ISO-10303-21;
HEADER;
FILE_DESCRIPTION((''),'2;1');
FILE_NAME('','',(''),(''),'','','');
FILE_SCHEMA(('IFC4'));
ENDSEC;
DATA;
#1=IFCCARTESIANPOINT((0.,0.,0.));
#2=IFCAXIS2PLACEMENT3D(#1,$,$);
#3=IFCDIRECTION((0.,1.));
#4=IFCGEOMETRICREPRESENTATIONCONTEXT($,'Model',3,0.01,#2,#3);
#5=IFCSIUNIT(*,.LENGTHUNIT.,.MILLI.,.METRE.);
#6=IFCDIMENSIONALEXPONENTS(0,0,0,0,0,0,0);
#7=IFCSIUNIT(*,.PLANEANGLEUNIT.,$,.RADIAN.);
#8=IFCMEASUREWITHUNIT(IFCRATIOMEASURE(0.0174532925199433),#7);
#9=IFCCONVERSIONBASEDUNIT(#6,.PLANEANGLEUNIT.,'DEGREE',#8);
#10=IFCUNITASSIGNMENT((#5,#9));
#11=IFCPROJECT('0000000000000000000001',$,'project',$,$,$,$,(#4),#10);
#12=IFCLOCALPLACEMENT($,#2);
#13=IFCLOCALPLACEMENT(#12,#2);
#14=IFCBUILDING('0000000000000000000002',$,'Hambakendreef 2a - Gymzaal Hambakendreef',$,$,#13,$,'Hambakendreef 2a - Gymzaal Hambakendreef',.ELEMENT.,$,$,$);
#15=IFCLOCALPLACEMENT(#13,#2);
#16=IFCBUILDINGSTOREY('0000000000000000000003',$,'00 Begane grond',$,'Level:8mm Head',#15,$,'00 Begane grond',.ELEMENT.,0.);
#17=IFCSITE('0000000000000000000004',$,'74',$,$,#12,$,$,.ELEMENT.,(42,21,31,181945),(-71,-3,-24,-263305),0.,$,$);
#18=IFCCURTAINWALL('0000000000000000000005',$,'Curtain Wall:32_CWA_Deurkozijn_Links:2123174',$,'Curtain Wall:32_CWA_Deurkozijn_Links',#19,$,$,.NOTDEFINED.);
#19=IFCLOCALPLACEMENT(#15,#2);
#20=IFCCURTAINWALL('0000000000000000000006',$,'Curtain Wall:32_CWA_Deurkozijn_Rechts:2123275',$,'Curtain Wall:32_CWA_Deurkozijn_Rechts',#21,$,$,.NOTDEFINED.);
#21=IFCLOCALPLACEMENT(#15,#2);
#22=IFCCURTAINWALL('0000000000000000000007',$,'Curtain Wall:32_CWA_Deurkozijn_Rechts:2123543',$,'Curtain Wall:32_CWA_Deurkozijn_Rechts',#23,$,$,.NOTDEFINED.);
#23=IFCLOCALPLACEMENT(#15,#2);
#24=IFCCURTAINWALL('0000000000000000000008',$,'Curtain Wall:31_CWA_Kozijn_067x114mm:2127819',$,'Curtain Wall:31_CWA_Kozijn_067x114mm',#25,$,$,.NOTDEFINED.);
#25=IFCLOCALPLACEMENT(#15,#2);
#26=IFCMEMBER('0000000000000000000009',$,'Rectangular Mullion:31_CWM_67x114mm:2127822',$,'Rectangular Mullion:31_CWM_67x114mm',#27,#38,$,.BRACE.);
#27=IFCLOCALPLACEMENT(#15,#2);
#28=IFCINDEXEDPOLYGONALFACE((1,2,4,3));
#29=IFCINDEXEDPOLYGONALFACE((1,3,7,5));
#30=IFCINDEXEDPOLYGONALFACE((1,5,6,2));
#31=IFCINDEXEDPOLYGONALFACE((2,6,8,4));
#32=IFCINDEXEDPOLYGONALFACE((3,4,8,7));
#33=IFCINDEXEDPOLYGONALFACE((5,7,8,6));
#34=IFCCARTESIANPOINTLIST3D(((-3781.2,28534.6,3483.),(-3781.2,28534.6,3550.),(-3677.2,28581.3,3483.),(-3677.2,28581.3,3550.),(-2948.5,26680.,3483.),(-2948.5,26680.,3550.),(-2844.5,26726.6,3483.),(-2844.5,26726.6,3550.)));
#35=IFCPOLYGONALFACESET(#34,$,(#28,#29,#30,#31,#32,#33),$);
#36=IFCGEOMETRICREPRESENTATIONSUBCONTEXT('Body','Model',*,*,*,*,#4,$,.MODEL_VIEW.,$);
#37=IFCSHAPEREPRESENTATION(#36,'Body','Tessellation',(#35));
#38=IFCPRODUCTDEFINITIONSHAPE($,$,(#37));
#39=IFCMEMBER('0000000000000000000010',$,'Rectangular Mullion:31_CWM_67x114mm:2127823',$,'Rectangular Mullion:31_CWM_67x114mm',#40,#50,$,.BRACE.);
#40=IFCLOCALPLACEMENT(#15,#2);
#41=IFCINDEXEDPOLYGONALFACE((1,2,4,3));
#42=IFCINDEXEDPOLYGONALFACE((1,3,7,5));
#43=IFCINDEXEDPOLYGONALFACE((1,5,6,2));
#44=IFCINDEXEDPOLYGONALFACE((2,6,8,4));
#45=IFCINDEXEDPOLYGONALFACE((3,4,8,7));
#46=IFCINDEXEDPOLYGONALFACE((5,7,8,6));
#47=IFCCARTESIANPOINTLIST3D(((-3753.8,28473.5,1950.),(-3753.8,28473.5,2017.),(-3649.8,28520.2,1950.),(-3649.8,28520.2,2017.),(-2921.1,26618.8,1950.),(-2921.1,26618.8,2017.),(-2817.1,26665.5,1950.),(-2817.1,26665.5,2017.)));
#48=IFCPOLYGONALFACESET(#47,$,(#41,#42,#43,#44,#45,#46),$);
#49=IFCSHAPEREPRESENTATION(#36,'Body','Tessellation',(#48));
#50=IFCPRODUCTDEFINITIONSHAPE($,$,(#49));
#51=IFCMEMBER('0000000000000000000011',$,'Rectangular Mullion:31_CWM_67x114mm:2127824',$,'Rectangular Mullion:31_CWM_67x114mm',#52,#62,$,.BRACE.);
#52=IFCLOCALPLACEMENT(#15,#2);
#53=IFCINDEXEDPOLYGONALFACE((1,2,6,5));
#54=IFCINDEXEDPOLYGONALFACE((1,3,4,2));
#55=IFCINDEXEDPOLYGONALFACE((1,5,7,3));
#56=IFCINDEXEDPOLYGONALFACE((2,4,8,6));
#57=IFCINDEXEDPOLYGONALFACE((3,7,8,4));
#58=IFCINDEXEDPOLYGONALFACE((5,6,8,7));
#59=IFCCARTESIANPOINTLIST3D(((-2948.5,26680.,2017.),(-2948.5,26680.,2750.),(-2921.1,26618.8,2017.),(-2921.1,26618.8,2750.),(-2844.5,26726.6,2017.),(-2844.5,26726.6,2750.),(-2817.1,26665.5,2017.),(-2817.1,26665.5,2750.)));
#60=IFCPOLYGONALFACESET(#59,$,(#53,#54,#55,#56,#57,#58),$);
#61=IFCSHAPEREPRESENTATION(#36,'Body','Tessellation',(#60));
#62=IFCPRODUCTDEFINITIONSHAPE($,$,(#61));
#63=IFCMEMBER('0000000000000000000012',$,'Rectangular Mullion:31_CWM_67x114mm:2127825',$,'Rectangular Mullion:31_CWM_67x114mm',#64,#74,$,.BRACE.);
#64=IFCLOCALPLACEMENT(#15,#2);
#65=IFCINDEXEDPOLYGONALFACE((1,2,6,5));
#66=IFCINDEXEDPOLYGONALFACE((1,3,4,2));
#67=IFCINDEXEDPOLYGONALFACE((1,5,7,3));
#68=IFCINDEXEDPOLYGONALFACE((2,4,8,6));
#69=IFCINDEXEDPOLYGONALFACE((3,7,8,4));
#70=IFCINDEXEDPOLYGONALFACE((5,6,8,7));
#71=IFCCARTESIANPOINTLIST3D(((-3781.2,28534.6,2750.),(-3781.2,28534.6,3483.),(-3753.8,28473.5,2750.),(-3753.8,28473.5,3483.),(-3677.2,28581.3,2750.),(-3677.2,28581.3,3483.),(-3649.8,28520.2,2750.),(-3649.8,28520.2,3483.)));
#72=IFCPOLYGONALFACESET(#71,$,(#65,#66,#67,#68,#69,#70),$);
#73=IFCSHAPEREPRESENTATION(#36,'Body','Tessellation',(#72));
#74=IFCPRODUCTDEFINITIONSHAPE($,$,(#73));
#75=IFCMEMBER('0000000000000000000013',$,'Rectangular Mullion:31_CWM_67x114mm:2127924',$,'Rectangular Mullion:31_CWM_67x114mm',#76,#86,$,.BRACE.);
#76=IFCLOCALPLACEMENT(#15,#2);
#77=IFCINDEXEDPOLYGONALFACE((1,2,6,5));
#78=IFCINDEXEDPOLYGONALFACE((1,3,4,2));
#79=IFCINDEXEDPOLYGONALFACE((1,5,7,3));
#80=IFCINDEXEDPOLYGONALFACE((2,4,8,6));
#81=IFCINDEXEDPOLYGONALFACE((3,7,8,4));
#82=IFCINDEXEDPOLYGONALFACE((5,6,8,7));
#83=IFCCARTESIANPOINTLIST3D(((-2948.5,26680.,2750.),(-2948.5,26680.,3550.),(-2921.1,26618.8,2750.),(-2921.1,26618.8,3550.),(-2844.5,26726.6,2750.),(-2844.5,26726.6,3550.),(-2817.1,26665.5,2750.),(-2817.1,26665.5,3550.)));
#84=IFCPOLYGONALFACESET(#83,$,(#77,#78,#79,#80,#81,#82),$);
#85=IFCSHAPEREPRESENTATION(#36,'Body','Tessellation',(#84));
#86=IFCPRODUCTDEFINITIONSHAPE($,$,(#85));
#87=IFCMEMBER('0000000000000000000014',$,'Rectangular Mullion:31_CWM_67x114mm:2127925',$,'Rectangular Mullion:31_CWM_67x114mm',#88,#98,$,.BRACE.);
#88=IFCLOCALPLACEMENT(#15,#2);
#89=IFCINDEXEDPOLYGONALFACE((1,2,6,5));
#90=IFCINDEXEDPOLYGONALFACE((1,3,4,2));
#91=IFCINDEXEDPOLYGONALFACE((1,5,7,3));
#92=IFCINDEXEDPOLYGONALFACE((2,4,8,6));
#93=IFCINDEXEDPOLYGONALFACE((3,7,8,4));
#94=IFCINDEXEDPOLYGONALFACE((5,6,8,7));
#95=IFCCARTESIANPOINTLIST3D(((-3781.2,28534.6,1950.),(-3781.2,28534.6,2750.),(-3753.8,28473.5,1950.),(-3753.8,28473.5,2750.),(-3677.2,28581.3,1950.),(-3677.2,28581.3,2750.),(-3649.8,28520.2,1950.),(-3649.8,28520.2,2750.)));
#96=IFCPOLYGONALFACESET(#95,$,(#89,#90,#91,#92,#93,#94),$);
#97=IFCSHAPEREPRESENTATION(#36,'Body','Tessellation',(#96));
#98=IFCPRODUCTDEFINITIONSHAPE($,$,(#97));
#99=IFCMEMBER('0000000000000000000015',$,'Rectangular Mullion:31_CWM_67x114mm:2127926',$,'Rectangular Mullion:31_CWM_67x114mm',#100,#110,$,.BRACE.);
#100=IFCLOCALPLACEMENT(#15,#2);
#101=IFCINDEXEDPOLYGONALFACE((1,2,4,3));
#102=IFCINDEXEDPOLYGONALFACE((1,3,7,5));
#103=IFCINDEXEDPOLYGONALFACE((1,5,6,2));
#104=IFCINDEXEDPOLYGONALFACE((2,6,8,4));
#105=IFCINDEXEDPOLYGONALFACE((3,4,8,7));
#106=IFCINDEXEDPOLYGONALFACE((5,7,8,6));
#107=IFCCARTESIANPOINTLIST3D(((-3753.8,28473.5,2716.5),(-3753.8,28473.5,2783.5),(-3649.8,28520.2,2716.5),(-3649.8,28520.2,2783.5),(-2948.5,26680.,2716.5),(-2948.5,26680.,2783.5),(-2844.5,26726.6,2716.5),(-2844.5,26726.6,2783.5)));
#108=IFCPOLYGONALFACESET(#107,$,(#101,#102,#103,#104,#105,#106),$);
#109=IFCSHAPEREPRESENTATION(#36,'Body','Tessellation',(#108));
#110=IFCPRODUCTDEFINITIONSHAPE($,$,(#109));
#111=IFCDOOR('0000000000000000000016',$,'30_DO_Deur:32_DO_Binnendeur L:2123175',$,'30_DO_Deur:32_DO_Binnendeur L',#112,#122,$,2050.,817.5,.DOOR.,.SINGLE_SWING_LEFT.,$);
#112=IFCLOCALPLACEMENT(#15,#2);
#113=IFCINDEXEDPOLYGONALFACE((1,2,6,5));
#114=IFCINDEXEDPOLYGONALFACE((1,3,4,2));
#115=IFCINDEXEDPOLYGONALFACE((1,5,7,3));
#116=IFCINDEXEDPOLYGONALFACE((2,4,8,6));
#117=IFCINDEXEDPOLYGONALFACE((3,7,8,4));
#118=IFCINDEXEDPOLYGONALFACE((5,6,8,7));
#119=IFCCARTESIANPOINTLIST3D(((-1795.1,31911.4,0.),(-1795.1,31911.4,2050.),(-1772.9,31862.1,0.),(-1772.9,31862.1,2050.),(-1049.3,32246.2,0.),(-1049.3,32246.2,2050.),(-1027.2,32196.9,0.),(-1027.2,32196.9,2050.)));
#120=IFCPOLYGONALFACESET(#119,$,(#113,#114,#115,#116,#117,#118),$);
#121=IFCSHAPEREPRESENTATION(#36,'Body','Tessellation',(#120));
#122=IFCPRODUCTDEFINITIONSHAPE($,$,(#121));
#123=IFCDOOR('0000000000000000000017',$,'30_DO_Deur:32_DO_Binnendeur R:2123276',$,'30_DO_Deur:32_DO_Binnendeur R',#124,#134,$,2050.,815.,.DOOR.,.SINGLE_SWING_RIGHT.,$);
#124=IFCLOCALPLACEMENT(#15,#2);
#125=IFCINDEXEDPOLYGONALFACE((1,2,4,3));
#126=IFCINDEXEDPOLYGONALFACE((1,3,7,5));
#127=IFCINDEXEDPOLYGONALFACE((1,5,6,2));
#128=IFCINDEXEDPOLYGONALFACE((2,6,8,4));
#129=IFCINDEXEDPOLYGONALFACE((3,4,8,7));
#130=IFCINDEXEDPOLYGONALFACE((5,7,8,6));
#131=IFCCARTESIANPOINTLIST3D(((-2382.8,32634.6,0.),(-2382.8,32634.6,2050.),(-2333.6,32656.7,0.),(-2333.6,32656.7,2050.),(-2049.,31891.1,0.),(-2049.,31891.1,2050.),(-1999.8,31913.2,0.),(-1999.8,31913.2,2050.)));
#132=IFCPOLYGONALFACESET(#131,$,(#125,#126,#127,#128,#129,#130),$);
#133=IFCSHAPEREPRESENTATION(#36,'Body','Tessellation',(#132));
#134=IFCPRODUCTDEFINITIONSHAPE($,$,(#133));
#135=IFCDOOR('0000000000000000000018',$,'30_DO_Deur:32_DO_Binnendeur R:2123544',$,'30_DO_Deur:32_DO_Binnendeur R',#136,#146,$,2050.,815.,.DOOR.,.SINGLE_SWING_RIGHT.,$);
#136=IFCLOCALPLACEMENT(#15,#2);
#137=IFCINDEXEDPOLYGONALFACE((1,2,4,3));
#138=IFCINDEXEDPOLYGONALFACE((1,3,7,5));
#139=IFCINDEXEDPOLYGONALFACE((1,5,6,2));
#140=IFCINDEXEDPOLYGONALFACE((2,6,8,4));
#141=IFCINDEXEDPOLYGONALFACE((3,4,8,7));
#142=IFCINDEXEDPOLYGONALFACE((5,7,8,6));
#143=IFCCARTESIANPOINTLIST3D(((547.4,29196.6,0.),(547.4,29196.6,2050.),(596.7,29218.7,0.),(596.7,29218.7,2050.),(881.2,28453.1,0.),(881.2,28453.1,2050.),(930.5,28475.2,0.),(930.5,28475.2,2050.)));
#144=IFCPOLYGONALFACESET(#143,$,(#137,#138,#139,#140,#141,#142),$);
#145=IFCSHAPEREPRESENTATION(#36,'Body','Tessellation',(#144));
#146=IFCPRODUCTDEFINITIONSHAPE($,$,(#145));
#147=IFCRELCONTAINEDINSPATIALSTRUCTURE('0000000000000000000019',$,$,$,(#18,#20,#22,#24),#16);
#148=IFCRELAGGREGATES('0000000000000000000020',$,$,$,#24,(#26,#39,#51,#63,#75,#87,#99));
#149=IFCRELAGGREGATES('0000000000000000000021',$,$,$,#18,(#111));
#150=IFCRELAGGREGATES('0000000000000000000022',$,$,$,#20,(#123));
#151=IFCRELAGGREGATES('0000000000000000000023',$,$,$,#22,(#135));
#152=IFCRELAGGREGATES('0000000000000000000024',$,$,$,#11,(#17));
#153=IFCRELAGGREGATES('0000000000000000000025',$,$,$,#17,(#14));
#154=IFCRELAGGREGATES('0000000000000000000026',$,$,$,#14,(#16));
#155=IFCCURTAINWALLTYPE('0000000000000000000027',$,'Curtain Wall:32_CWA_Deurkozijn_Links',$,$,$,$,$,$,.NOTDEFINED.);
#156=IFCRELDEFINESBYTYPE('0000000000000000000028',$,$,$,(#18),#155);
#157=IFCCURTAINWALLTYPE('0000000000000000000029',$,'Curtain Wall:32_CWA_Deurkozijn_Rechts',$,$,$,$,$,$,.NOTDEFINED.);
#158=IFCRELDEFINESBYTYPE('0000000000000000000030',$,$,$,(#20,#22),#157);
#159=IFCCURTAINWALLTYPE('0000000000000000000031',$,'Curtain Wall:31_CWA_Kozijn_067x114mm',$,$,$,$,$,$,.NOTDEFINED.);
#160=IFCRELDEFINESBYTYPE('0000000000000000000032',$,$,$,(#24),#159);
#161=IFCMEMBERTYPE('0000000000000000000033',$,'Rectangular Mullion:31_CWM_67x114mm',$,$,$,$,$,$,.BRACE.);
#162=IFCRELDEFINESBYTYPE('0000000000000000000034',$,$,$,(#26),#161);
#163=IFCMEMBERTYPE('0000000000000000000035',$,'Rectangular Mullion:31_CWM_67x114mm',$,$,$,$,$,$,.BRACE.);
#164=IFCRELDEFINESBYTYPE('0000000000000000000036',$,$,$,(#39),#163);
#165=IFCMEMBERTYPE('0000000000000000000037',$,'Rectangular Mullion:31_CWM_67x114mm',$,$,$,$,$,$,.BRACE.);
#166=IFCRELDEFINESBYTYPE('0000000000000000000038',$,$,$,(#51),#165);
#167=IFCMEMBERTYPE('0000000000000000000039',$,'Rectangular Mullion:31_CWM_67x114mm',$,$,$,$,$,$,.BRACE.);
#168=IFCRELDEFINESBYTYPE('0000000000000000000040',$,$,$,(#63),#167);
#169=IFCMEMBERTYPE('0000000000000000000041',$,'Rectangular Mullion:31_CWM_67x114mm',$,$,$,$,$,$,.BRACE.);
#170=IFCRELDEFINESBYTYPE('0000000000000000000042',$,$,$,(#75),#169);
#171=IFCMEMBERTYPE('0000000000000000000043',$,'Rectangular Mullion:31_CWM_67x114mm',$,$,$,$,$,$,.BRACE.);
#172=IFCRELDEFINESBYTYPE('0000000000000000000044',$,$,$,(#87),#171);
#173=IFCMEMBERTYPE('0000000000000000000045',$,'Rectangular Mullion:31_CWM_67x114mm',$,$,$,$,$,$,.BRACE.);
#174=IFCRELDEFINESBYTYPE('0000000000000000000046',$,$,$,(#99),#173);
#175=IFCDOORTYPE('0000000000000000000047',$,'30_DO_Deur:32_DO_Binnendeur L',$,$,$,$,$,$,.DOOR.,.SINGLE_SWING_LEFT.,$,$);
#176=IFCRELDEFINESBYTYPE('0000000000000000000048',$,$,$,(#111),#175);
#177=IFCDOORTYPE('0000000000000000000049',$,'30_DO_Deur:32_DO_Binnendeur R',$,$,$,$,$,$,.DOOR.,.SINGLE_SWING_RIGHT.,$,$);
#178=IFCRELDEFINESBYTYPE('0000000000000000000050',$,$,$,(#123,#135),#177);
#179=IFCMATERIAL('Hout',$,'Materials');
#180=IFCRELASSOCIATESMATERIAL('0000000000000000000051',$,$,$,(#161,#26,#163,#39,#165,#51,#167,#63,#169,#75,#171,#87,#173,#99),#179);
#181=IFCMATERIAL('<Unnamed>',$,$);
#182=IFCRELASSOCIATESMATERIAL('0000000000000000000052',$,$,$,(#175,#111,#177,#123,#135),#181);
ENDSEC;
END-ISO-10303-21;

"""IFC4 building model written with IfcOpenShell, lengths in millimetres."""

from ifc_helpers import new_model, entity, si_unit, converted_unit, direction, frame, origin, place, context, subcontext, project, spatial, indexed_curve, outline, extrude, source, transform, mapped, material, type_object, type_shapes, element, aggregate, save


model = new_model("IFC4")

# Units and contexts
model_context = context("Model", 3, precision=0.01, world=origin(), true_north=direction((0.0, 1.0)))
body_context = subcontext(model_context, "Body", "Model", "MODEL_VIEW")
ifc_project = project(units=[si_unit("LENGTHUNIT", "METRE", prefix="MILLI"), converted_unit("PLANEANGLEUNIT", "DEGREE", entity("IfcRatioMeasure", 0.0174532925199433), si_unit("PLANEANGLEUNIT", "RADIAN"), dimensions=[0, 0, 0, 0, 0, 0, 0])], contexts=[model_context])

# Site, building, storey
site_placement = place(None, origin())
site = spatial("IfcSite", under=ifc_project, at=site_placement, Name="74", CompositionType="ELEMENT", RefLatitude=(42, 21, 31, 181945), RefLongitude=(-71, -3, -24, -263305), RefElevation=0.0)
building_placement = place(site_placement, origin())
building = spatial("IfcBuilding", under=site, at=building_placement, Name="Hambakendreef 2a - Gymzaal Hambakendreef", LongName="Hambakendreef 2a - Gymzaal Hambakendreef", CompositionType="ELEMENT")
storey_placement = place(building_placement, origin())
storey = spatial("IfcBuildingStorey", under=building, at=storey_placement, Name="00 Begane grond", ObjectType="Level:8mm Head", LongName="00 Begane grond", CompositionType="ELEMENT", Elevation=0.0)

# Curtain walls
curtain_wall_type_1 = type_object("IfcCurtainWallType", Name="Curtain Wall:32_CWA_Deurkozijn_Rechts", PredefinedType="NOTDEFINED")
ifc_material_1 = material(Name="Hout", Category="Materials")
curtain_wall_type_2 = type_object("IfcCurtainWallType", Name="Curtain Wall:32_CWA_Deurkozijn_Links", PredefinedType="NOTDEFINED")
curtain_wall_1_placement = place(storey_placement, origin())
curtain_wall_1 = element("IfcCurtainWall", 1, at=curtain_wall_1_placement, inside=storey, type_object=curtain_wall_type_2, Name="Curtain Wall:32_CWA_Deurkozijn_Links:2123174", ObjectType="Curtain Wall:32_CWA_Deurkozijn_Links", PredefinedType="NOTDEFINED")
curtain_wall_2_placement = place(storey_placement, origin())
curtain_wall_2 = element("IfcCurtainWall", 2, at=curtain_wall_2_placement, inside=storey, type_object=curtain_wall_type_1, Name="Curtain Wall:32_CWA_Deurkozijn_Rechts:2123275", ObjectType="Curtain Wall:32_CWA_Deurkozijn_Rechts", PredefinedType="NOTDEFINED")

# Curtain wall
curtain_wall_3_placement = place(storey_placement, origin())
curtain_wall_3 = element("IfcCurtainWall", 3, at=curtain_wall_3_placement, inside=storey, type_object=curtain_wall_type_1, Name="Curtain Wall:32_CWA_Deurkozijn_Rechts:2123543", ObjectType="Curtain Wall:32_CWA_Deurkozijn_Rechts", PredefinedType="NOTDEFINED")

# Curtain wall, members
curtain_wall_type_3 = type_object("IfcCurtainWallType", Name="Curtain Wall:31_CWA_Kozijn_067x114mm", PredefinedType="NOTDEFINED")
curtain_wall_4_placement = place(storey_placement, origin())
curtain_wall_4 = element("IfcCurtainWall", 4, at=curtain_wall_4_placement, inside=storey, type_object=curtain_wall_type_3, Name="Curtain Wall:31_CWA_Kozijn_067x114mm:2127819", ObjectType="Curtain Wall:31_CWA_Kozijn_067x114mm", PredefinedType="NOTDEFINED")
member_type_1 = type_object("IfcMemberType", Name="Rectangular Mullion:31_CWM_67x114mm", PredefinedType="BRACE", material=ifc_material_1)
shared_shape_1 = source(origin(), body_context, "Body", "SweptSolid", [
    extrude(outline(indexed_curve([(-57.0, -33.5), (57.0, -33.5), (57.0, 33.5), (-57.0, 33.5), (-57.0, -33.5)], self_intersect=False)), frame((-33.5, 0.0, -2033.0), z_axis=(0.0, 0.0, 1.0), x_axis=(0.0, -1.0, 0.0)), (0.0, 0.0, 1.0), 2033.0),
])
type_shapes(member_type_1, [shared_shape_1])
member_1_placement = place(storey_placement, frame((-2896.5, 26703.3, 3550.0), z_axis=(0.40959, -0.91227, 0.0), x_axis=(0.0, 0.0, 1.0)))
member_1 = element("IfcMember", 5, at=member_1_placement, type_object=member_type_1, material=ifc_material_1, Name="Rectangular Mullion:31_CWM_67x114mm:2127822", ObjectType="Rectangular Mullion:31_CWM_67x114mm", PredefinedType="BRACE", context=body_context, shape_type="MappedRepresentation", body=[
    mapped(shared_shape_1, transform((0.0, 0.0, 0.0), scale=1.0)),
])
member_type_2 = type_object("IfcMemberType", Name="Rectangular Mullion:31_CWM_67x114mm", PredefinedType="BRACE", material=ifc_material_1)
shared_shape_2 = source(origin(), body_context, "Body", "SweptSolid", [
    extrude(outline(indexed_curve([(-57.0, -33.5), (57.0, -33.5), (57.0, 33.5), (-57.0, 33.5), (-57.0, -33.5)], self_intersect=False)), frame((-33.5, 0.0, -2033.0), z_axis=(0.0, 0.0, 1.0), x_axis=(0.0, -1.0, 0.0)), (0.0, 0.0, 1.0), 2033.0),
])
type_shapes(member_type_2, [shared_shape_2])
member_2_placement = place(storey_placement, frame((-3701.8, 28496.8, 1950.0), z_axis=(-0.40959, 0.91227, 0.0), x_axis=(0.0, 0.0, -1.0)))
member_2 = element("IfcMember", 6, at=member_2_placement, type_object=member_type_2, material=ifc_material_1, Name="Rectangular Mullion:31_CWM_67x114mm:2127823", ObjectType="Rectangular Mullion:31_CWM_67x114mm", PredefinedType="BRACE", context=body_context, shape_type="MappedRepresentation", body=[
    mapped(shared_shape_2, transform((0.0, 0.0, 0.0), scale=1.0)),
])
member_type_3 = type_object("IfcMemberType", Name="Rectangular Mullion:31_CWM_67x114mm", PredefinedType="BRACE", material=ifc_material_1)
shared_shape_3 = source(origin(), body_context, "Body", "SweptSolid", [
    extrude(outline(indexed_curve([(-57.0, -33.5), (57.0, -33.5), (57.0, 33.5), (-57.0, 33.5), (-57.0, -33.5)], self_intersect=False)), frame((-33.5, 0.0, -733.0), z_axis=(0.0, 0.0, 1.0), x_axis=(0.0, -1.0, 0.0)), (0.0, 0.0, 1.0), 733.0),
])
type_shapes(member_type_3, [shared_shape_3])
member_3_placement = place(storey_placement, frame((-2869.1, 26642.2, 2017.0), z_axis=(0.0, 0.0, -1.0), x_axis=(0.40959, -0.91227, 0.0)))
member_3 = element("IfcMember", 7, at=member_3_placement, type_object=member_type_3, material=ifc_material_1, Name="Rectangular Mullion:31_CWM_67x114mm:2127824", ObjectType="Rectangular Mullion:31_CWM_67x114mm", PredefinedType="BRACE", context=body_context, shape_type="MappedRepresentation", body=[
    mapped(shared_shape_3, transform((0.0, 0.0, 0.0), scale=1.0)),
])
member_type_4 = type_object("IfcMemberType", Name="Rectangular Mullion:31_CWM_67x114mm", PredefinedType="BRACE", material=ifc_material_1)
shared_shape_4 = source(origin(), body_context, "Body", "SweptSolid", [
    extrude(outline(indexed_curve([(-57.0, -33.5), (57.0, -33.5), (57.0, 33.5), (-57.0, 33.5), (-57.0, -33.5)], self_intersect=False)), frame((-33.5, 0.0, -733.0), z_axis=(0.0, 0.0, 1.0), x_axis=(0.0, -1.0, 0.0)), (0.0, 0.0, 1.0), 733.0),
])
type_shapes(member_type_4, [shared_shape_4])
member_4_placement = place(storey_placement, frame((-3729.2, 28557.9, 3483.0), z_axis=(0.0, 0.0, 1.0), x_axis=(-0.40959, 0.91227, 0.0)))
member_4 = element("IfcMember", 8, at=member_4_placement, type_object=member_type_4, material=ifc_material_1, Name="Rectangular Mullion:31_CWM_67x114mm:2127825", ObjectType="Rectangular Mullion:31_CWM_67x114mm", PredefinedType="BRACE", context=body_context, shape_type="MappedRepresentation", body=[
    mapped(shared_shape_4, transform((0.0, 0.0, 0.0), scale=1.0)),
])
member_type_5 = type_object("IfcMemberType", Name="Rectangular Mullion:31_CWM_67x114mm", PredefinedType="BRACE", material=ifc_material_1)
shared_shape_5 = source(origin(), body_context, "Body", "SweptSolid", [
    extrude(outline(indexed_curve([(-57.0, -33.5), (57.0, -33.5), (57.0, 33.5), (-57.0, 33.5), (-57.0, -33.5)], self_intersect=False)), frame((-33.5, 0.0, -800.0), z_axis=(0.0, 0.0, 1.0), x_axis=(0.0, -1.0, 0.0)), (0.0, 0.0, 1.0), 800.0),
])
type_shapes(member_type_5, [shared_shape_5])
member_5_placement = place(storey_placement, frame((-2869.1, 26642.2, 2750.0), z_axis=(0.0, 0.0, -1.0), x_axis=(0.40959, -0.91227, 0.0)))
member_5 = element("IfcMember", 9, at=member_5_placement, type_object=member_type_5, material=ifc_material_1, Name="Rectangular Mullion:31_CWM_67x114mm:2127924", ObjectType="Rectangular Mullion:31_CWM_67x114mm", PredefinedType="BRACE", context=body_context, shape_type="MappedRepresentation", body=[
    mapped(shared_shape_5, transform((0.0, 0.0, 0.0), scale=1.0)),
])
member_type_6 = type_object("IfcMemberType", Name="Rectangular Mullion:31_CWM_67x114mm", PredefinedType="BRACE", material=ifc_material_1)
shared_shape_6 = source(origin(), body_context, "Body", "SweptSolid", [
    extrude(outline(indexed_curve([(-57.0, -33.5), (57.0, -33.5), (57.0, 33.5), (-57.0, 33.5), (-57.0, -33.5)], self_intersect=False)), frame((-33.5, 0.0, -800.0), z_axis=(0.0, 0.0, 1.0), x_axis=(0.0, -1.0, 0.0)), (0.0, 0.0, 1.0), 800.0),
])
type_shapes(member_type_6, [shared_shape_6])
member_6_placement = place(storey_placement, frame((-3729.2, 28557.9, 2750.0), z_axis=(0.0, 0.0, 1.0), x_axis=(-0.40959, 0.91227, 0.0)))
member_6 = element("IfcMember", 10, at=member_6_placement, type_object=member_type_6, material=ifc_material_1, Name="Rectangular Mullion:31_CWM_67x114mm:2127925", ObjectType="Rectangular Mullion:31_CWM_67x114mm", PredefinedType="BRACE", context=body_context, shape_type="MappedRepresentation", body=[
    mapped(shared_shape_6, transform((0.0, 0.0, 0.0), scale=1.0)),
])
member_type_7 = type_object("IfcMemberType", Name="Rectangular Mullion:31_CWM_67x114mm", PredefinedType="BRACE", material=ifc_material_1)
shared_shape_7 = source(origin(), body_context, "Body", "SweptSolid", [
    extrude(outline(indexed_curve([(-57.0, -33.5), (57.0, -33.5), (57.0, 33.5), (-57.0, 33.5), (-57.0, -33.5)], self_intersect=False)), frame((0.0, 0.0, -1966.0), z_axis=(0.0, 0.0, 1.0), x_axis=(0.0, -1.0, 0.0)), (0.0, 0.0, 1.0), 1966.0),
])
type_shapes(member_type_7, [shared_shape_7])
member_7_placement = place(storey_placement, frame((-2896.5, 26703.3, 2750.0), z_axis=(0.40959, -0.91227, 0.0), x_axis=(0.0, 0.0, 1.0)))
member_7 = element("IfcMember", 11, at=member_7_placement, type_object=member_type_7, material=ifc_material_1, Name="Rectangular Mullion:31_CWM_67x114mm:2127926", ObjectType="Rectangular Mullion:31_CWM_67x114mm", PredefinedType="BRACE", context=body_context, shape_type="MappedRepresentation", body=[
    mapped(shared_shape_7, transform((0.0, 0.0, 0.0), scale=1.0)),
])
aggregate(curtain_wall_4, [member_1, member_2, member_3, member_4, member_5, member_6, member_7])

# Doors
ifc_material_2 = material(Name="<Unnamed>")
door_type_1 = type_object("IfcDoorType", Name="30_DO_Deur:32_DO_Binnendeur L", OperationType="SINGLE_SWING_LEFT", PredefinedType="DOOR", material=ifc_material_2)
shared_shape_8 = source(origin(), body_context, "Body", "SweptSolid", [
    extrude(outline(indexed_curve([(-27.0, -408.7), (27.0, -408.7), (27.0, 408.7), (-27.0, 408.7), (-27.0, -408.7)], self_intersect=False)), frame((0.0, 0.0, 0.0), z_axis=(0.0, 0.0, 1.0), x_axis=(0.0, 1.0, 0.0)), (0.0, 0.0, 1.0), 2050.0),
])
type_shapes(door_type_1, [shared_shape_8])
door_1_placement = place(curtain_wall_1_placement, frame((-1411.1, 32054.1, 0.0), z_axis=(0.0, 0.0, 1.0), x_axis=(-0.91227, -0.40959, 0.0)))
door_1 = element("IfcDoor", 12, at=door_1_placement, type_object=door_type_1, material=ifc_material_2, Name="30_DO_Deur:32_DO_Binnendeur L:2123175", ObjectType="30_DO_Deur:32_DO_Binnendeur L", OperationType="SINGLE_SWING_LEFT", OverallHeight=2050.0, OverallWidth=817.5, PredefinedType="DOOR", context=body_context, shape_type="MappedRepresentation", body=[
    mapped(shared_shape_8, transform((0.0, 0.0, 0.0), scale=1.0)),
])
aggregate(curtain_wall_1, [door_1])
door_type_2 = type_object("IfcDoorType", Name="30_DO_Deur:32_DO_Binnendeur R", OperationType="SINGLE_SWING_RIGHT", PredefinedType="DOOR", material=ifc_material_2)
shared_shape_9 = source(origin(), body_context, "Body", "SweptSolid", [
    extrude(outline(indexed_curve([(-27.0, -407.5), (27.0, -407.5), (27.0, 407.5), (-27.0, 407.5), (-27.0, -407.5)], self_intersect=False)), frame((0.0, 0.0, 0.0), z_axis=(0.0, 0.0, 1.0), x_axis=(0.0, 1.0, 0.0)), (0.0, 0.0, 1.0), 2050.0),
])
type_shapes(door_type_2, [shared_shape_9])
door_2_placement = place(curtain_wall_2_placement, frame((-2191.3, 32273.9, 0.0), z_axis=(0.0, 0.0, 1.0), x_axis=(0.40959, -0.91227, 0.0)))
door_2 = element("IfcDoor", 13, at=door_2_placement, type_object=door_type_2, material=ifc_material_2, Name="30_DO_Deur:32_DO_Binnendeur R:2123276", ObjectType="30_DO_Deur:32_DO_Binnendeur R", OperationType="SINGLE_SWING_RIGHT", OverallHeight=2050.0, OverallWidth=815.0, PredefinedType="DOOR", context=body_context, shape_type="MappedRepresentation", body=[
    mapped(shared_shape_9, transform((0.0, 0.0, 0.0), scale=1.0)),
])
aggregate(curtain_wall_2, [door_2])
door_3_placement = place(curtain_wall_3_placement, frame((738.9, 28835.9, 0.0), z_axis=(0.0, 0.0, 1.0), x_axis=(0.40959, -0.91227, 0.0)))
door_3 = element("IfcDoor", 14, at=door_3_placement, type_object=door_type_2, material=ifc_material_2, Name="30_DO_Deur:32_DO_Binnendeur R:2123544", ObjectType="30_DO_Deur:32_DO_Binnendeur R", OperationType="SINGLE_SWING_RIGHT", OverallHeight=2050.0, OverallWidth=815.0, PredefinedType="DOOR", context=body_context, shape_type="MappedRepresentation", body=[
    mapped(shared_shape_9, transform((0.0, 0.0, 0.0), scale=1.0)),
])
aggregate(curtain_wall_3, [door_3])

save(model, "model.ifc")
